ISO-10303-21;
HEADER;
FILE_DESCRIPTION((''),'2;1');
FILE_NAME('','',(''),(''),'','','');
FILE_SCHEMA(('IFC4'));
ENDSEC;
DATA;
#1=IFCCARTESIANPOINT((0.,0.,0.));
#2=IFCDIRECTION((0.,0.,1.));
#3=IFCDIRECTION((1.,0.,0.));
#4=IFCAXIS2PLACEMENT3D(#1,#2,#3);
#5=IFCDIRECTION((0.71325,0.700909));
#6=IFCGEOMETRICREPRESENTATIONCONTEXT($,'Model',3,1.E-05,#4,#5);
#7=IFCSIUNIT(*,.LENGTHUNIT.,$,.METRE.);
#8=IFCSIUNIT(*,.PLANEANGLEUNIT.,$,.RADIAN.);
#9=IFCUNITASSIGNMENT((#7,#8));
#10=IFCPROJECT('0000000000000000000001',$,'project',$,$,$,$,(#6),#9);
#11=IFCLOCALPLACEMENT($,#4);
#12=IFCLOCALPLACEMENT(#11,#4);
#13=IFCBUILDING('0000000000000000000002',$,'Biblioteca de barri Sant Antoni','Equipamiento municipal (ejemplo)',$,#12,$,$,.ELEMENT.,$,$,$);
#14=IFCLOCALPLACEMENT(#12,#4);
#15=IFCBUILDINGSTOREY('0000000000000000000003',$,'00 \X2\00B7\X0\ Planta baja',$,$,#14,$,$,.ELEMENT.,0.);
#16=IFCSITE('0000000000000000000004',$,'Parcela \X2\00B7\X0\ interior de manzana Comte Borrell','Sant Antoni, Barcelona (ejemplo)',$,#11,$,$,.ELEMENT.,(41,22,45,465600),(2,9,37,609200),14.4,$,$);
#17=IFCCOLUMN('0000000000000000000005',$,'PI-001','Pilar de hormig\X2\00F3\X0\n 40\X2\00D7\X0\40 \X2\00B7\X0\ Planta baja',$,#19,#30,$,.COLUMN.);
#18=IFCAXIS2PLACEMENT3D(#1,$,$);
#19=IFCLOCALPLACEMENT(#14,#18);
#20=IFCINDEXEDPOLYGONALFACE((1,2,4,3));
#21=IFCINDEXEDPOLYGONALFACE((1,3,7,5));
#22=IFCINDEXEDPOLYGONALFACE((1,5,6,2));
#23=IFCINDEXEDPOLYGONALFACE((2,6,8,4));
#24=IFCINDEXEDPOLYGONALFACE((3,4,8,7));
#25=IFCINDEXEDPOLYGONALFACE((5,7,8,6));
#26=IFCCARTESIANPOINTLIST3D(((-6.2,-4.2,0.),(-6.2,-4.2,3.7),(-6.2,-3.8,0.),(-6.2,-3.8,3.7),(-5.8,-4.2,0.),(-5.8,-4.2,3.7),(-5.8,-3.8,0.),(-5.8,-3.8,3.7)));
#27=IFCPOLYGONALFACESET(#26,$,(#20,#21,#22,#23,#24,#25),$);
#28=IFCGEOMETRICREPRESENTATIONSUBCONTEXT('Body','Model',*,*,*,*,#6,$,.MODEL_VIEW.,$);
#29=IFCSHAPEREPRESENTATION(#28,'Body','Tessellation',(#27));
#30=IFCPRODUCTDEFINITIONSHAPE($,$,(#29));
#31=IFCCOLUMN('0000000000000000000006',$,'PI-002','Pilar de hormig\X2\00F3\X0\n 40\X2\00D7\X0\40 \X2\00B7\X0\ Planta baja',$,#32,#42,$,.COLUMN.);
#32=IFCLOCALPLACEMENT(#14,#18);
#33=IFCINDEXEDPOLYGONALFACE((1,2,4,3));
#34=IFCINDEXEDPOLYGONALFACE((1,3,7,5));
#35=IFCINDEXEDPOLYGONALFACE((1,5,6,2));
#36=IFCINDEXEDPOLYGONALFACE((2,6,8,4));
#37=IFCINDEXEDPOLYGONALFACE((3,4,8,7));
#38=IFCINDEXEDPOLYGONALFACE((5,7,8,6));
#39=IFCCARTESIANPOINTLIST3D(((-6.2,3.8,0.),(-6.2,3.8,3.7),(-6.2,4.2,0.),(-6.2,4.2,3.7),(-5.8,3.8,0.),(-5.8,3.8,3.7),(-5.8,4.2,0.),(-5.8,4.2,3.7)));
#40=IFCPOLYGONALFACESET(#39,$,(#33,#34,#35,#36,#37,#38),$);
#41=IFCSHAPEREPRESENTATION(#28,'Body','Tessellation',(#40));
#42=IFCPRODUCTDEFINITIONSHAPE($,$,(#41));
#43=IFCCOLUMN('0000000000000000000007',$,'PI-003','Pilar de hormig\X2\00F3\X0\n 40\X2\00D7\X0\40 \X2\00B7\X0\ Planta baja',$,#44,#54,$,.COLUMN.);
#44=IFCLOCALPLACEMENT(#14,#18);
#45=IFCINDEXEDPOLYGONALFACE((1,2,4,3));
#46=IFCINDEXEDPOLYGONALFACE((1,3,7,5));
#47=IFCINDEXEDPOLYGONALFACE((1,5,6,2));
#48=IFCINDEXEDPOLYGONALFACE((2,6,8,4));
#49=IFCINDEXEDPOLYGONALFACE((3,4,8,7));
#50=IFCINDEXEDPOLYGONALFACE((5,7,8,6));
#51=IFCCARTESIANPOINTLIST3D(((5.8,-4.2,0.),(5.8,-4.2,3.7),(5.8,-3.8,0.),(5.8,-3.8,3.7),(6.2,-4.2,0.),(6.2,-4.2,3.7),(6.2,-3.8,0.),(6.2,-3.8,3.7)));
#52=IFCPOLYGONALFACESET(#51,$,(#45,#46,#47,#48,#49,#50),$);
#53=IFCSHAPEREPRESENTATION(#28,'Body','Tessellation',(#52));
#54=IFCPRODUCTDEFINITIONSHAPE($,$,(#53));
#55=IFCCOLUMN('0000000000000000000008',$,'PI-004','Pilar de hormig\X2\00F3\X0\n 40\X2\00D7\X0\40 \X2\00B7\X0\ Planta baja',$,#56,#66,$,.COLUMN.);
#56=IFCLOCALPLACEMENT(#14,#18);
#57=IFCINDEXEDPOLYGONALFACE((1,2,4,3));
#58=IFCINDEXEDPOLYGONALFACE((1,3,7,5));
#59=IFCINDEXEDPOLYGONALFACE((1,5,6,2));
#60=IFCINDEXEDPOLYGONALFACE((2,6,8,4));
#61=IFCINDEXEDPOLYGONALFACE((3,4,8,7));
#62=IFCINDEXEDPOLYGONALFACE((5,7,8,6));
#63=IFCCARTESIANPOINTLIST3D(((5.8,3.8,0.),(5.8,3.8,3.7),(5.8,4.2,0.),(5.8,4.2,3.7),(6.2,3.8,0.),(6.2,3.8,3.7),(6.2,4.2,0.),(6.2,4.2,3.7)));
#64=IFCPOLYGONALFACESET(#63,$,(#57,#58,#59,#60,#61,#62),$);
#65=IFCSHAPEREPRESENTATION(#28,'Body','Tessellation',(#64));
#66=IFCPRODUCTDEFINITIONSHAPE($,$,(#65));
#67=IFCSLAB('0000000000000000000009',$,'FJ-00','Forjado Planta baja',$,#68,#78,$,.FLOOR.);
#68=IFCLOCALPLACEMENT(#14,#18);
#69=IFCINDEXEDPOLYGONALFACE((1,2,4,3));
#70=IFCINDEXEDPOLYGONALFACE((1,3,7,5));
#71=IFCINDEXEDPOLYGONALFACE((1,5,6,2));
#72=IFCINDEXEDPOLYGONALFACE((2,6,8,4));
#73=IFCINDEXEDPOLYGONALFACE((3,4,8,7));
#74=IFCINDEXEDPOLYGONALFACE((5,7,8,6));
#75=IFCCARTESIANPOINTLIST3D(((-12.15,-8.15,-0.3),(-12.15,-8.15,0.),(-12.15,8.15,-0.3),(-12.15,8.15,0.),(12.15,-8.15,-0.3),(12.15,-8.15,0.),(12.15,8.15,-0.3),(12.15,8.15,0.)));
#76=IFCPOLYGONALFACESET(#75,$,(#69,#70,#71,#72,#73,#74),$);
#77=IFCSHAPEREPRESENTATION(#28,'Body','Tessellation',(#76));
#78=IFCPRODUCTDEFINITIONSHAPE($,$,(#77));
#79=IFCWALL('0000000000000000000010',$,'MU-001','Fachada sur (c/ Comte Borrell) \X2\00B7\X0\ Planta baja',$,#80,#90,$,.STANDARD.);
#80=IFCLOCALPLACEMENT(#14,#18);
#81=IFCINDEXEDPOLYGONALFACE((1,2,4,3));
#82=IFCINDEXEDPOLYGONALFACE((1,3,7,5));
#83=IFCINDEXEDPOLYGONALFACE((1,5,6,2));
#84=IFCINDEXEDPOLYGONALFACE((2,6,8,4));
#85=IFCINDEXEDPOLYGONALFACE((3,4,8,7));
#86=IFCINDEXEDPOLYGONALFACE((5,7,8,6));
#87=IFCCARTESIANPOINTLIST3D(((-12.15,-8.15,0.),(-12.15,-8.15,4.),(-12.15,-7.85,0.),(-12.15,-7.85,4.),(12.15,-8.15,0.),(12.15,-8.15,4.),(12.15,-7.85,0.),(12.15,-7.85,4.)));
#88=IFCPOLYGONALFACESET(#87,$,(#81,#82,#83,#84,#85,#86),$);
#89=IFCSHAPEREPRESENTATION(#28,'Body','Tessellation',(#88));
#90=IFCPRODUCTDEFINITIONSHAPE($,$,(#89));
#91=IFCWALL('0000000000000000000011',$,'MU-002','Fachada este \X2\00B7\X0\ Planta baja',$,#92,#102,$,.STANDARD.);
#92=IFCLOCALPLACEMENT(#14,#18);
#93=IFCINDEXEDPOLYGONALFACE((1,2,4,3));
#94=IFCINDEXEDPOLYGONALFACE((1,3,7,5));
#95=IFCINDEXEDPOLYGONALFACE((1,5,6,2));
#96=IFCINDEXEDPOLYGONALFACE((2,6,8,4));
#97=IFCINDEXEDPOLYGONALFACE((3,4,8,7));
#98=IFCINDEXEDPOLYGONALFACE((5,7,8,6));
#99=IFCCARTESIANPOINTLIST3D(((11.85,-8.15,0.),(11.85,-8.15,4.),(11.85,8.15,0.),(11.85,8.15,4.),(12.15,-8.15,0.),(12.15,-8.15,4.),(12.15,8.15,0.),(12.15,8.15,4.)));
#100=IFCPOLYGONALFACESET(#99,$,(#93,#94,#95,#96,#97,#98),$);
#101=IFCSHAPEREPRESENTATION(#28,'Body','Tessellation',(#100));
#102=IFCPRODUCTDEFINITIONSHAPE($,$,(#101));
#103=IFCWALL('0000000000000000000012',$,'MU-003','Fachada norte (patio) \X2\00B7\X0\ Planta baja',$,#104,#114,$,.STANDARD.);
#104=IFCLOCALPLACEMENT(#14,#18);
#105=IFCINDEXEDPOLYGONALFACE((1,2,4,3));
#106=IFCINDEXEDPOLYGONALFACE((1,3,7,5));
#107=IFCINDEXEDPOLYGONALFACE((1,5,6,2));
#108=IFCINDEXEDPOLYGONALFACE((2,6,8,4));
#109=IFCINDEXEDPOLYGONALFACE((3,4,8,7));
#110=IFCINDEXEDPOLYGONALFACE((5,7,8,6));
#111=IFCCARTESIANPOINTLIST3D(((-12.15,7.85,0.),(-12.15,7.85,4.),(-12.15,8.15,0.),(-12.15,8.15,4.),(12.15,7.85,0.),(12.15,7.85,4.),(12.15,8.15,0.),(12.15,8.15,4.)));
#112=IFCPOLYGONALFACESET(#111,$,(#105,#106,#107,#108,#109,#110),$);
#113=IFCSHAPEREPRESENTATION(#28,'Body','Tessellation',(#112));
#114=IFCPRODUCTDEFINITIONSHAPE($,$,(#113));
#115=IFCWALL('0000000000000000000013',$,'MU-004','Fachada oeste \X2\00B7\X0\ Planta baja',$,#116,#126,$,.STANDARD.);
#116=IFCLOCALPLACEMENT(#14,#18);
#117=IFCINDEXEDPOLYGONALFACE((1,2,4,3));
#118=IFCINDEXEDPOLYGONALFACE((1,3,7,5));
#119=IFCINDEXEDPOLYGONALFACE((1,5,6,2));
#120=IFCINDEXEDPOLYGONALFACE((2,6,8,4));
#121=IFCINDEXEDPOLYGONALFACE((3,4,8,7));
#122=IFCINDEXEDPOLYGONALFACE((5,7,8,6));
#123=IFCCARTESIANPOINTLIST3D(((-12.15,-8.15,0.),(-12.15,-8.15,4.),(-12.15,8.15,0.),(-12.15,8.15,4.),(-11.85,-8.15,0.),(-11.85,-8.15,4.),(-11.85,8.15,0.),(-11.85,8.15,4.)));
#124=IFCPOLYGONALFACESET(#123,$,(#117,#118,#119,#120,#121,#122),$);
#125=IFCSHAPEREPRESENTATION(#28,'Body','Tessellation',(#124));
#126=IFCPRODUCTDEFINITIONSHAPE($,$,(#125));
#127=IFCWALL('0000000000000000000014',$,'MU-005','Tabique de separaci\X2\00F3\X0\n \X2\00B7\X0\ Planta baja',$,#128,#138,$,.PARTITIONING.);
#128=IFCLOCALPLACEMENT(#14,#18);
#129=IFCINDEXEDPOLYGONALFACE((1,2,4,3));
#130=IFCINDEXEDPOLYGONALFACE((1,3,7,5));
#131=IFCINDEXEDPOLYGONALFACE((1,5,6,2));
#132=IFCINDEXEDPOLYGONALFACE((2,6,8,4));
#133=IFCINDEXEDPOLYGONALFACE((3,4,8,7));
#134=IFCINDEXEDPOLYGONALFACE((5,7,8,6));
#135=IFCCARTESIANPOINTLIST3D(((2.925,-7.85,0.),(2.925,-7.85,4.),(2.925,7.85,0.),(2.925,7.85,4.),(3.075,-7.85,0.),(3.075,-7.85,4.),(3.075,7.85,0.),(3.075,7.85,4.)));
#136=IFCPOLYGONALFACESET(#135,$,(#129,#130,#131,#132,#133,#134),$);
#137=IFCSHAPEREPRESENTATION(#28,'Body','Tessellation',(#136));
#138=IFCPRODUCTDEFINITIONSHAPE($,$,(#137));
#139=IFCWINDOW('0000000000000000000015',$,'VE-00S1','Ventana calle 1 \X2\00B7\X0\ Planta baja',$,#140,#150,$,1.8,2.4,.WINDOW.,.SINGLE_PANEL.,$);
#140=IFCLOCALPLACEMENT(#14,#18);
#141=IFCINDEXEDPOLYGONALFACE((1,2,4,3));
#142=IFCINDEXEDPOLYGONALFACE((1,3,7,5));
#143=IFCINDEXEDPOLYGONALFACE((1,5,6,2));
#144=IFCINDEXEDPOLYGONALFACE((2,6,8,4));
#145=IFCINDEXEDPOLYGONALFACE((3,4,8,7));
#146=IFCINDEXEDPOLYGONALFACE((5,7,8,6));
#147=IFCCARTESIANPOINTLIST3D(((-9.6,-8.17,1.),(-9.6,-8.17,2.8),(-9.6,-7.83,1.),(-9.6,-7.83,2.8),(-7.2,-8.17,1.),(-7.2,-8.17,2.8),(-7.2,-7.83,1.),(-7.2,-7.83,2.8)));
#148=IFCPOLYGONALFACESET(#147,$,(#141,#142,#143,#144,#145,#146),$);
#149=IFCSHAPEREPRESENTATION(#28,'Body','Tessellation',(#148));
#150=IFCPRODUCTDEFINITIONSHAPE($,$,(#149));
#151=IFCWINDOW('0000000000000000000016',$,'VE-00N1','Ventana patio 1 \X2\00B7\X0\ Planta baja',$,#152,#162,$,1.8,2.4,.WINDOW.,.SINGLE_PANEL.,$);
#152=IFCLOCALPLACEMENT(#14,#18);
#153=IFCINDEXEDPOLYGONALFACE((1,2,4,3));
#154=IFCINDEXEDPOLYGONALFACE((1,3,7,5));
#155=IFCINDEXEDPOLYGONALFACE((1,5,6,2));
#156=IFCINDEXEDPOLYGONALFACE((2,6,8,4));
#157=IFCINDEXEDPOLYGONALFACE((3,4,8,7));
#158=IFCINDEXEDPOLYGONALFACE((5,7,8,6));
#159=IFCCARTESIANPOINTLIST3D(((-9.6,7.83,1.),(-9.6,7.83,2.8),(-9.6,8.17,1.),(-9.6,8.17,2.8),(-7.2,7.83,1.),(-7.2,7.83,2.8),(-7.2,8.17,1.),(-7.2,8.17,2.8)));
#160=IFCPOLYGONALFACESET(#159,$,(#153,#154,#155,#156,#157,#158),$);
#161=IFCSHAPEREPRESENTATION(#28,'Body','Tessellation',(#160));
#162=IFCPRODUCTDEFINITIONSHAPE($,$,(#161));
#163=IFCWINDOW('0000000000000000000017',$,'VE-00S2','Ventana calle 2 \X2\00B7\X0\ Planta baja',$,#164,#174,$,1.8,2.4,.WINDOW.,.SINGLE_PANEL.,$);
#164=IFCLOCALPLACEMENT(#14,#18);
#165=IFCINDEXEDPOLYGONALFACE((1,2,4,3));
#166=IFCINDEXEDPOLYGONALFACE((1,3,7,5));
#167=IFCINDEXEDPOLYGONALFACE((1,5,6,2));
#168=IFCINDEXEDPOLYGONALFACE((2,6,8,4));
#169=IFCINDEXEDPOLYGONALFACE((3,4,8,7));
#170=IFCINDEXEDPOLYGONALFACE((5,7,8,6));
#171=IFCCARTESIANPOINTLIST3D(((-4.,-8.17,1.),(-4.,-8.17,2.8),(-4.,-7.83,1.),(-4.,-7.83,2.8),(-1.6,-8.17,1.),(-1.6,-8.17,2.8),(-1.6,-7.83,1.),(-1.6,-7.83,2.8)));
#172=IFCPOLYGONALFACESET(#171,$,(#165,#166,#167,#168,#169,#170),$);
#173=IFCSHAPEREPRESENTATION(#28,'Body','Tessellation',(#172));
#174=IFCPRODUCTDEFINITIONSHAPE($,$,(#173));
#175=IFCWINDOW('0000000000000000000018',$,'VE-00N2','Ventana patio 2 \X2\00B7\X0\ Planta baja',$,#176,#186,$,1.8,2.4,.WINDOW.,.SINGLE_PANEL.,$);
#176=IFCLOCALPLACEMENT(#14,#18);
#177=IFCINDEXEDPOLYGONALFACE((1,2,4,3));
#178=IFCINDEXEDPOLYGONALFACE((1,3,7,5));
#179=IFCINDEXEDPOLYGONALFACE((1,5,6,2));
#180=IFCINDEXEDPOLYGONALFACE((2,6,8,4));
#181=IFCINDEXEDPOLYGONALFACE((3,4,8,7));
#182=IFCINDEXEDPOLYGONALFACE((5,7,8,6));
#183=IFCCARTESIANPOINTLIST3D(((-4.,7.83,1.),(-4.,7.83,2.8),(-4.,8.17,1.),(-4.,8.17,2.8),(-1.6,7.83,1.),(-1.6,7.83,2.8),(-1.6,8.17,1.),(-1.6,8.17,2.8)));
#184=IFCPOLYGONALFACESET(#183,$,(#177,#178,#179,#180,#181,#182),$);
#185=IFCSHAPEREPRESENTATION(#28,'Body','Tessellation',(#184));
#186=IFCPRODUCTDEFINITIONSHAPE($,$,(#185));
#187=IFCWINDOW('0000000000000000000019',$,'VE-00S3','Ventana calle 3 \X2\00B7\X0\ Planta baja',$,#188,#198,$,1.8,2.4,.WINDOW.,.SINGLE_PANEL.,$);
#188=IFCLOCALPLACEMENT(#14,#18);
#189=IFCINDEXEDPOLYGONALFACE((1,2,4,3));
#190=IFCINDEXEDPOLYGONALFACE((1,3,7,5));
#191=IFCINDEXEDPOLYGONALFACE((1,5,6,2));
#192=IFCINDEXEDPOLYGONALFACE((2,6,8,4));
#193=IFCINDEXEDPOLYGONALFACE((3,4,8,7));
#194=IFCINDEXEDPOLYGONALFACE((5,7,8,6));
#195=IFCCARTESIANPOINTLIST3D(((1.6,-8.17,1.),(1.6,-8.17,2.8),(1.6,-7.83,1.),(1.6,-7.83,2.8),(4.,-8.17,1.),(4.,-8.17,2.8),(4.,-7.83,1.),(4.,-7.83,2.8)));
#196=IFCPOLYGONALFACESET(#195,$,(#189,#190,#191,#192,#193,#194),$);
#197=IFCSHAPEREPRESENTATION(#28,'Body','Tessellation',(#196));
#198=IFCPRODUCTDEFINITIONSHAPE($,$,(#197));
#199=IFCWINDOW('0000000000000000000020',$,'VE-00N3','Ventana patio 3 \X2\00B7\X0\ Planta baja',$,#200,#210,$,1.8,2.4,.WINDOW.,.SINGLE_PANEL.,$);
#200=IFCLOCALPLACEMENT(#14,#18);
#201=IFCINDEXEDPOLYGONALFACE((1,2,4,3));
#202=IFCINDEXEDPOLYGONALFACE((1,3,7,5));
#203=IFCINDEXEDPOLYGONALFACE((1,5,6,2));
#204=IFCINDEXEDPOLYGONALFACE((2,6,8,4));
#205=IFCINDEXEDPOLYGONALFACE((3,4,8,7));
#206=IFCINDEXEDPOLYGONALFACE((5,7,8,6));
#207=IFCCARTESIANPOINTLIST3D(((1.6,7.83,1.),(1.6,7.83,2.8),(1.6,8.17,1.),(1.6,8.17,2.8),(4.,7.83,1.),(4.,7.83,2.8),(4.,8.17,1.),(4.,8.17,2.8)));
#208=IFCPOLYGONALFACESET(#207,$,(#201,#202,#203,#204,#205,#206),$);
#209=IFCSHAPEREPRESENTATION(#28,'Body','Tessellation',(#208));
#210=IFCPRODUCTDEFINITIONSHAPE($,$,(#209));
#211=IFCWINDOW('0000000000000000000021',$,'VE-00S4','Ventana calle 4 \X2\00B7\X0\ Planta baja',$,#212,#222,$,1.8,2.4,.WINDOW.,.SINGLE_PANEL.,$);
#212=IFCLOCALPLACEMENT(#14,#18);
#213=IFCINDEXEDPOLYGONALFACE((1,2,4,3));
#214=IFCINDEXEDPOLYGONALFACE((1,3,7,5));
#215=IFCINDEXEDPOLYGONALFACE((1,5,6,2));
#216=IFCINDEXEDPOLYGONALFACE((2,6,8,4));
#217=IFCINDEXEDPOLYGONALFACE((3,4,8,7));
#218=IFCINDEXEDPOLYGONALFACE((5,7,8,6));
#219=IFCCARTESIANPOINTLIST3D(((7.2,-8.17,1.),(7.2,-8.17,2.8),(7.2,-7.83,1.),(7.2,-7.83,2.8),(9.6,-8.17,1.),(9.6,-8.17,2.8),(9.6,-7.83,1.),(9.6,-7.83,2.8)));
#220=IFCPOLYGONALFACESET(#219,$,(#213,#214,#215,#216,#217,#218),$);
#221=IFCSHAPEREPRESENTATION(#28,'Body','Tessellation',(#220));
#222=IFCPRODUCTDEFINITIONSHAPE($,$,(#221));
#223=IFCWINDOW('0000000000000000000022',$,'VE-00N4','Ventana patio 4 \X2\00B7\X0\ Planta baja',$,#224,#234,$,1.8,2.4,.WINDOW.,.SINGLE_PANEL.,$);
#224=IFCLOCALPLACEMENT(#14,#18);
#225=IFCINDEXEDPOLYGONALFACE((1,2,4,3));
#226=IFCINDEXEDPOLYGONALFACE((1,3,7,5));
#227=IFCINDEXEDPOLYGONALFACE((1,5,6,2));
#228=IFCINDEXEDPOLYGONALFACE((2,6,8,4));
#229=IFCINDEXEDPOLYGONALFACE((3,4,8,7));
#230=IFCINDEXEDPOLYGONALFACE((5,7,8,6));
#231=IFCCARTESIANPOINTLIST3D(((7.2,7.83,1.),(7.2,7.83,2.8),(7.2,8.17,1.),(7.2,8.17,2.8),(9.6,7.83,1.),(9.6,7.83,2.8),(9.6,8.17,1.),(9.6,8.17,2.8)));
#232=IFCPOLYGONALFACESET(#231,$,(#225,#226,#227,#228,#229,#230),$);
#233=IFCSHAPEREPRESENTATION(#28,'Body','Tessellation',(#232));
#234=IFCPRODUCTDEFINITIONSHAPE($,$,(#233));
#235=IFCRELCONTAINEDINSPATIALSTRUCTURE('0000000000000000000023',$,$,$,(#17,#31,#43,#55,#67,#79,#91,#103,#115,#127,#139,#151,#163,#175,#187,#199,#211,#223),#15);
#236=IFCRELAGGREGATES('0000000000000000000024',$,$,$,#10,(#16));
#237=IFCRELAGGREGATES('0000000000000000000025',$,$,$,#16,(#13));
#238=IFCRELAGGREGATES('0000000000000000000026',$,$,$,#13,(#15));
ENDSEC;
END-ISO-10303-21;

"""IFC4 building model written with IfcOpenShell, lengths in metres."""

from ifc_helpers import new_model, si_unit, direction, frame, origin_with_axes, origin_2d, place, context, subcontext, project, spatial, rectangle, extrude, element, save


model = new_model("IFC4")

# Units and contexts
model_context = context("Model", 3, precision=1e-05, world=origin_with_axes(), true_north=direction((0.71325, 0.700909)))
body_context = subcontext(model_context, "Body", "Model", "MODEL_VIEW")
ifc_project = project(units=[si_unit("LENGTHUNIT", "METRE"), si_unit("PLANEANGLEUNIT", "RADIAN")], contexts=[model_context])

# Site, building, storey
site_placement = place(None, origin_with_axes())
site = spatial("IfcSite", under=ifc_project, at=site_placement, Name="Parcela · interior de manzana Comte Borrell", Description="Sant Antoni, Barcelona (ejemplo)", CompositionType="ELEMENT", RefLatitude=(41, 22, 45, 465600), RefLongitude=(2, 9, 37, 609200), RefElevation=14.4)
building_placement = place(site_placement, origin_with_axes())
building = spatial("IfcBuilding", under=site, at=building_placement, Name="Biblioteca de barri Sant Antoni", Description="Equipamiento municipal (ejemplo)", CompositionType="ELEMENT")
storey_placement = place(building_placement, origin_with_axes())
storey = spatial("IfcBuildingStorey", under=building, at=storey_placement, Name="00 · Planta baja", CompositionType="ELEMENT", Elevation=0.0)

# Columns
for number, where, z_axis, x_axis, name in (
    (1, (-6.0, -4.0, 0.0), (0.0, 0.0, 1.0), (1.0, 0.0, 0.0), "PI-001"),
    (2, (-6.0, 4.0, 0.0), (0.0, 0.0, 1.0), (1.0, 0.0, 0.0), "PI-002"),
    (3, (6.0, -4.0, 0.0), (0.0, 0.0, 1.0), (1.0, 0.0, 0.0), "PI-003"),
    (4, (6.0, 4.0, 0.0), (0.0, 0.0, 1.0), (1.0, 0.0, 0.0), "PI-004"),
):
    element("IfcColumn", number, at=place(storey_placement, frame(where, z_axis=z_axis, x_axis=x_axis)), inside=storey, Name=name, Description="Pilar de hormigón 40×40 · Planta baja", PredefinedType="COLUMN", context=body_context, shape_type="SweptSolid", body=[
        extrude(rectangle(XDim=0.4, YDim=0.4, at=origin_2d()), origin_with_axes(), (0.0, 0.0, 1.0), 3.7),
    ])

# Slab
slab_placement = place(storey_placement, frame((0.0, 0.0, -0.3), z_axis=(0.0, 0.0, 1.0), x_axis=(1.0, 0.0, 0.0)))
element("IfcSlab", 5, at=slab_placement, inside=storey, Name="FJ-00", Description="Forjado Planta baja", PredefinedType="FLOOR", context=body_context, shape_type="SweptSolid", body=[
    extrude(rectangle(XDim=24.3, YDim=16.3, at=origin_2d()), origin_with_axes(), (0.0, 0.0, 1.0), 0.3),
])

# Walls
wall_1_placement = place(storey_placement, frame((0.0, -8.0, 0.0), z_axis=(0.0, 0.0, 1.0), x_axis=(1.0, 0.0, 0.0)))
element("IfcWall", 6, at=wall_1_placement, inside=storey, Name="MU-001", Description="Fachada sur (c/ Comte Borrell) · Planta baja", PredefinedType="STANDARD", context=body_context, shape_type="SweptSolid", body=[
    extrude(rectangle(XDim=24.3, YDim=0.3, at=origin_2d()), origin_with_axes(), (0.0, 0.0, 1.0), 4.0),
])
wall_2_placement = place(storey_placement, frame((12.0, 0.0, 0.0), z_axis=(0.0, 0.0, 1.0), x_axis=(0.0, 1.0, 0.0)))
element("IfcWall", 7, at=wall_2_placement, inside=storey, Name="MU-002", Description="Fachada este · Planta baja", PredefinedType="STANDARD", context=body_context, shape_type="SweptSolid", body=[
    extrude(rectangle(XDim=16.3, YDim=0.3, at=origin_2d()), origin_with_axes(), (0.0, 0.0, 1.0), 4.0),
])
wall_3_placement = place(storey_placement, frame((0.0, 8.0, 0.0), z_axis=(0.0, 0.0, 1.0), x_axis=(-1.0, 0.0, 0.0)))
element("IfcWall", 8, at=wall_3_placement, inside=storey, Name="MU-003", Description="Fachada norte (patio) · Planta baja", PredefinedType="STANDARD", context=body_context, shape_type="SweptSolid", body=[
    extrude(rectangle(XDim=24.3, YDim=0.3, at=origin_2d()), origin_with_axes(), (0.0, 0.0, 1.0), 4.0),
])
wall_4_placement = place(storey_placement, frame((-12.0, 0.0, 0.0), z_axis=(0.0, 0.0, 1.0), x_axis=(0.0, -1.0, 0.0)))
element("IfcWall", 9, at=wall_4_placement, inside=storey, Name="MU-004", Description="Fachada oeste · Planta baja", PredefinedType="STANDARD", context=body_context, shape_type="SweptSolid", body=[
    extrude(rectangle(XDim=16.3, YDim=0.3, at=origin_2d()), origin_with_axes(), (0.0, 0.0, 1.0), 4.0),
])
wall_5_placement = place(storey_placement, frame((3.0, 0.0, 0.0), z_axis=(0.0, 0.0, 1.0), x_axis=(1.0, 0.0, 0.0)))
element("IfcWall", 10, at=wall_5_placement, inside=storey, Name="MU-005", Description="Tabique de separación · Planta baja", PredefinedType="PARTITIONING", context=body_context, shape_type="SweptSolid", body=[
    extrude(rectangle(XDim=0.15, YDim=15.7, at=origin_2d()), origin_with_axes(), (0.0, 0.0, 1.0), 4.0),
])

# Windows
for number, where, z_axis, x_axis, name, description in (
    (11, (-8.4, -8.0, 1.0), (0.0, 0.0, 1.0), (1.0, 0.0, 0.0), "VE-00S1", "Ventana calle 1 · Planta baja"),
    (12, (-8.4, 8.0, 1.0), (0.0, 0.0, 1.0), (1.0, 0.0, 0.0), "VE-00N1", "Ventana patio 1 · Planta baja"),
    (13, (-2.8, -8.0, 1.0), (0.0, 0.0, 1.0), (1.0, 0.0, 0.0), "VE-00S2", "Ventana calle 2 · Planta baja"),
    (14, (-2.8, 8.0, 1.0), (0.0, 0.0, 1.0), (1.0, 0.0, 0.0), "VE-00N2", "Ventana patio 2 · Planta baja"),
    (15, (2.8, -8.0, 1.0), (0.0, 0.0, 1.0), (1.0, 0.0, 0.0), "VE-00S3", "Ventana calle 3 · Planta baja"),
    (16, (2.8, 8.0, 1.0), (0.0, 0.0, 1.0), (1.0, 0.0, 0.0), "VE-00N3", "Ventana patio 3 · Planta baja"),
    (17, (8.4, -8.0, 1.0), (0.0, 0.0, 1.0), (1.0, 0.0, 0.0), "VE-00S4", "Ventana calle 4 · Planta baja"),
    (18, (8.4, 8.0, 1.0), (0.0, 0.0, 1.0), (1.0, 0.0, 0.0), "VE-00N4", "Ventana patio 4 · Planta baja"),
):
    element("IfcWindow", number, at=place(storey_placement, frame(where, z_axis=z_axis, x_axis=x_axis)), inside=storey, Name=name, Description=description, OverallHeight=1.8, OverallWidth=2.4, PartitioningType="SINGLE_PANEL", PredefinedType="WINDOW", context=body_context, shape_type="SweptSolid", body=[
        extrude(rectangle(XDim=2.4, YDim=0.34, at=origin_2d()), origin_with_axes(), (0.0, 0.0, 1.0), 1.8),
    ])

save(model, "model.ifc")
